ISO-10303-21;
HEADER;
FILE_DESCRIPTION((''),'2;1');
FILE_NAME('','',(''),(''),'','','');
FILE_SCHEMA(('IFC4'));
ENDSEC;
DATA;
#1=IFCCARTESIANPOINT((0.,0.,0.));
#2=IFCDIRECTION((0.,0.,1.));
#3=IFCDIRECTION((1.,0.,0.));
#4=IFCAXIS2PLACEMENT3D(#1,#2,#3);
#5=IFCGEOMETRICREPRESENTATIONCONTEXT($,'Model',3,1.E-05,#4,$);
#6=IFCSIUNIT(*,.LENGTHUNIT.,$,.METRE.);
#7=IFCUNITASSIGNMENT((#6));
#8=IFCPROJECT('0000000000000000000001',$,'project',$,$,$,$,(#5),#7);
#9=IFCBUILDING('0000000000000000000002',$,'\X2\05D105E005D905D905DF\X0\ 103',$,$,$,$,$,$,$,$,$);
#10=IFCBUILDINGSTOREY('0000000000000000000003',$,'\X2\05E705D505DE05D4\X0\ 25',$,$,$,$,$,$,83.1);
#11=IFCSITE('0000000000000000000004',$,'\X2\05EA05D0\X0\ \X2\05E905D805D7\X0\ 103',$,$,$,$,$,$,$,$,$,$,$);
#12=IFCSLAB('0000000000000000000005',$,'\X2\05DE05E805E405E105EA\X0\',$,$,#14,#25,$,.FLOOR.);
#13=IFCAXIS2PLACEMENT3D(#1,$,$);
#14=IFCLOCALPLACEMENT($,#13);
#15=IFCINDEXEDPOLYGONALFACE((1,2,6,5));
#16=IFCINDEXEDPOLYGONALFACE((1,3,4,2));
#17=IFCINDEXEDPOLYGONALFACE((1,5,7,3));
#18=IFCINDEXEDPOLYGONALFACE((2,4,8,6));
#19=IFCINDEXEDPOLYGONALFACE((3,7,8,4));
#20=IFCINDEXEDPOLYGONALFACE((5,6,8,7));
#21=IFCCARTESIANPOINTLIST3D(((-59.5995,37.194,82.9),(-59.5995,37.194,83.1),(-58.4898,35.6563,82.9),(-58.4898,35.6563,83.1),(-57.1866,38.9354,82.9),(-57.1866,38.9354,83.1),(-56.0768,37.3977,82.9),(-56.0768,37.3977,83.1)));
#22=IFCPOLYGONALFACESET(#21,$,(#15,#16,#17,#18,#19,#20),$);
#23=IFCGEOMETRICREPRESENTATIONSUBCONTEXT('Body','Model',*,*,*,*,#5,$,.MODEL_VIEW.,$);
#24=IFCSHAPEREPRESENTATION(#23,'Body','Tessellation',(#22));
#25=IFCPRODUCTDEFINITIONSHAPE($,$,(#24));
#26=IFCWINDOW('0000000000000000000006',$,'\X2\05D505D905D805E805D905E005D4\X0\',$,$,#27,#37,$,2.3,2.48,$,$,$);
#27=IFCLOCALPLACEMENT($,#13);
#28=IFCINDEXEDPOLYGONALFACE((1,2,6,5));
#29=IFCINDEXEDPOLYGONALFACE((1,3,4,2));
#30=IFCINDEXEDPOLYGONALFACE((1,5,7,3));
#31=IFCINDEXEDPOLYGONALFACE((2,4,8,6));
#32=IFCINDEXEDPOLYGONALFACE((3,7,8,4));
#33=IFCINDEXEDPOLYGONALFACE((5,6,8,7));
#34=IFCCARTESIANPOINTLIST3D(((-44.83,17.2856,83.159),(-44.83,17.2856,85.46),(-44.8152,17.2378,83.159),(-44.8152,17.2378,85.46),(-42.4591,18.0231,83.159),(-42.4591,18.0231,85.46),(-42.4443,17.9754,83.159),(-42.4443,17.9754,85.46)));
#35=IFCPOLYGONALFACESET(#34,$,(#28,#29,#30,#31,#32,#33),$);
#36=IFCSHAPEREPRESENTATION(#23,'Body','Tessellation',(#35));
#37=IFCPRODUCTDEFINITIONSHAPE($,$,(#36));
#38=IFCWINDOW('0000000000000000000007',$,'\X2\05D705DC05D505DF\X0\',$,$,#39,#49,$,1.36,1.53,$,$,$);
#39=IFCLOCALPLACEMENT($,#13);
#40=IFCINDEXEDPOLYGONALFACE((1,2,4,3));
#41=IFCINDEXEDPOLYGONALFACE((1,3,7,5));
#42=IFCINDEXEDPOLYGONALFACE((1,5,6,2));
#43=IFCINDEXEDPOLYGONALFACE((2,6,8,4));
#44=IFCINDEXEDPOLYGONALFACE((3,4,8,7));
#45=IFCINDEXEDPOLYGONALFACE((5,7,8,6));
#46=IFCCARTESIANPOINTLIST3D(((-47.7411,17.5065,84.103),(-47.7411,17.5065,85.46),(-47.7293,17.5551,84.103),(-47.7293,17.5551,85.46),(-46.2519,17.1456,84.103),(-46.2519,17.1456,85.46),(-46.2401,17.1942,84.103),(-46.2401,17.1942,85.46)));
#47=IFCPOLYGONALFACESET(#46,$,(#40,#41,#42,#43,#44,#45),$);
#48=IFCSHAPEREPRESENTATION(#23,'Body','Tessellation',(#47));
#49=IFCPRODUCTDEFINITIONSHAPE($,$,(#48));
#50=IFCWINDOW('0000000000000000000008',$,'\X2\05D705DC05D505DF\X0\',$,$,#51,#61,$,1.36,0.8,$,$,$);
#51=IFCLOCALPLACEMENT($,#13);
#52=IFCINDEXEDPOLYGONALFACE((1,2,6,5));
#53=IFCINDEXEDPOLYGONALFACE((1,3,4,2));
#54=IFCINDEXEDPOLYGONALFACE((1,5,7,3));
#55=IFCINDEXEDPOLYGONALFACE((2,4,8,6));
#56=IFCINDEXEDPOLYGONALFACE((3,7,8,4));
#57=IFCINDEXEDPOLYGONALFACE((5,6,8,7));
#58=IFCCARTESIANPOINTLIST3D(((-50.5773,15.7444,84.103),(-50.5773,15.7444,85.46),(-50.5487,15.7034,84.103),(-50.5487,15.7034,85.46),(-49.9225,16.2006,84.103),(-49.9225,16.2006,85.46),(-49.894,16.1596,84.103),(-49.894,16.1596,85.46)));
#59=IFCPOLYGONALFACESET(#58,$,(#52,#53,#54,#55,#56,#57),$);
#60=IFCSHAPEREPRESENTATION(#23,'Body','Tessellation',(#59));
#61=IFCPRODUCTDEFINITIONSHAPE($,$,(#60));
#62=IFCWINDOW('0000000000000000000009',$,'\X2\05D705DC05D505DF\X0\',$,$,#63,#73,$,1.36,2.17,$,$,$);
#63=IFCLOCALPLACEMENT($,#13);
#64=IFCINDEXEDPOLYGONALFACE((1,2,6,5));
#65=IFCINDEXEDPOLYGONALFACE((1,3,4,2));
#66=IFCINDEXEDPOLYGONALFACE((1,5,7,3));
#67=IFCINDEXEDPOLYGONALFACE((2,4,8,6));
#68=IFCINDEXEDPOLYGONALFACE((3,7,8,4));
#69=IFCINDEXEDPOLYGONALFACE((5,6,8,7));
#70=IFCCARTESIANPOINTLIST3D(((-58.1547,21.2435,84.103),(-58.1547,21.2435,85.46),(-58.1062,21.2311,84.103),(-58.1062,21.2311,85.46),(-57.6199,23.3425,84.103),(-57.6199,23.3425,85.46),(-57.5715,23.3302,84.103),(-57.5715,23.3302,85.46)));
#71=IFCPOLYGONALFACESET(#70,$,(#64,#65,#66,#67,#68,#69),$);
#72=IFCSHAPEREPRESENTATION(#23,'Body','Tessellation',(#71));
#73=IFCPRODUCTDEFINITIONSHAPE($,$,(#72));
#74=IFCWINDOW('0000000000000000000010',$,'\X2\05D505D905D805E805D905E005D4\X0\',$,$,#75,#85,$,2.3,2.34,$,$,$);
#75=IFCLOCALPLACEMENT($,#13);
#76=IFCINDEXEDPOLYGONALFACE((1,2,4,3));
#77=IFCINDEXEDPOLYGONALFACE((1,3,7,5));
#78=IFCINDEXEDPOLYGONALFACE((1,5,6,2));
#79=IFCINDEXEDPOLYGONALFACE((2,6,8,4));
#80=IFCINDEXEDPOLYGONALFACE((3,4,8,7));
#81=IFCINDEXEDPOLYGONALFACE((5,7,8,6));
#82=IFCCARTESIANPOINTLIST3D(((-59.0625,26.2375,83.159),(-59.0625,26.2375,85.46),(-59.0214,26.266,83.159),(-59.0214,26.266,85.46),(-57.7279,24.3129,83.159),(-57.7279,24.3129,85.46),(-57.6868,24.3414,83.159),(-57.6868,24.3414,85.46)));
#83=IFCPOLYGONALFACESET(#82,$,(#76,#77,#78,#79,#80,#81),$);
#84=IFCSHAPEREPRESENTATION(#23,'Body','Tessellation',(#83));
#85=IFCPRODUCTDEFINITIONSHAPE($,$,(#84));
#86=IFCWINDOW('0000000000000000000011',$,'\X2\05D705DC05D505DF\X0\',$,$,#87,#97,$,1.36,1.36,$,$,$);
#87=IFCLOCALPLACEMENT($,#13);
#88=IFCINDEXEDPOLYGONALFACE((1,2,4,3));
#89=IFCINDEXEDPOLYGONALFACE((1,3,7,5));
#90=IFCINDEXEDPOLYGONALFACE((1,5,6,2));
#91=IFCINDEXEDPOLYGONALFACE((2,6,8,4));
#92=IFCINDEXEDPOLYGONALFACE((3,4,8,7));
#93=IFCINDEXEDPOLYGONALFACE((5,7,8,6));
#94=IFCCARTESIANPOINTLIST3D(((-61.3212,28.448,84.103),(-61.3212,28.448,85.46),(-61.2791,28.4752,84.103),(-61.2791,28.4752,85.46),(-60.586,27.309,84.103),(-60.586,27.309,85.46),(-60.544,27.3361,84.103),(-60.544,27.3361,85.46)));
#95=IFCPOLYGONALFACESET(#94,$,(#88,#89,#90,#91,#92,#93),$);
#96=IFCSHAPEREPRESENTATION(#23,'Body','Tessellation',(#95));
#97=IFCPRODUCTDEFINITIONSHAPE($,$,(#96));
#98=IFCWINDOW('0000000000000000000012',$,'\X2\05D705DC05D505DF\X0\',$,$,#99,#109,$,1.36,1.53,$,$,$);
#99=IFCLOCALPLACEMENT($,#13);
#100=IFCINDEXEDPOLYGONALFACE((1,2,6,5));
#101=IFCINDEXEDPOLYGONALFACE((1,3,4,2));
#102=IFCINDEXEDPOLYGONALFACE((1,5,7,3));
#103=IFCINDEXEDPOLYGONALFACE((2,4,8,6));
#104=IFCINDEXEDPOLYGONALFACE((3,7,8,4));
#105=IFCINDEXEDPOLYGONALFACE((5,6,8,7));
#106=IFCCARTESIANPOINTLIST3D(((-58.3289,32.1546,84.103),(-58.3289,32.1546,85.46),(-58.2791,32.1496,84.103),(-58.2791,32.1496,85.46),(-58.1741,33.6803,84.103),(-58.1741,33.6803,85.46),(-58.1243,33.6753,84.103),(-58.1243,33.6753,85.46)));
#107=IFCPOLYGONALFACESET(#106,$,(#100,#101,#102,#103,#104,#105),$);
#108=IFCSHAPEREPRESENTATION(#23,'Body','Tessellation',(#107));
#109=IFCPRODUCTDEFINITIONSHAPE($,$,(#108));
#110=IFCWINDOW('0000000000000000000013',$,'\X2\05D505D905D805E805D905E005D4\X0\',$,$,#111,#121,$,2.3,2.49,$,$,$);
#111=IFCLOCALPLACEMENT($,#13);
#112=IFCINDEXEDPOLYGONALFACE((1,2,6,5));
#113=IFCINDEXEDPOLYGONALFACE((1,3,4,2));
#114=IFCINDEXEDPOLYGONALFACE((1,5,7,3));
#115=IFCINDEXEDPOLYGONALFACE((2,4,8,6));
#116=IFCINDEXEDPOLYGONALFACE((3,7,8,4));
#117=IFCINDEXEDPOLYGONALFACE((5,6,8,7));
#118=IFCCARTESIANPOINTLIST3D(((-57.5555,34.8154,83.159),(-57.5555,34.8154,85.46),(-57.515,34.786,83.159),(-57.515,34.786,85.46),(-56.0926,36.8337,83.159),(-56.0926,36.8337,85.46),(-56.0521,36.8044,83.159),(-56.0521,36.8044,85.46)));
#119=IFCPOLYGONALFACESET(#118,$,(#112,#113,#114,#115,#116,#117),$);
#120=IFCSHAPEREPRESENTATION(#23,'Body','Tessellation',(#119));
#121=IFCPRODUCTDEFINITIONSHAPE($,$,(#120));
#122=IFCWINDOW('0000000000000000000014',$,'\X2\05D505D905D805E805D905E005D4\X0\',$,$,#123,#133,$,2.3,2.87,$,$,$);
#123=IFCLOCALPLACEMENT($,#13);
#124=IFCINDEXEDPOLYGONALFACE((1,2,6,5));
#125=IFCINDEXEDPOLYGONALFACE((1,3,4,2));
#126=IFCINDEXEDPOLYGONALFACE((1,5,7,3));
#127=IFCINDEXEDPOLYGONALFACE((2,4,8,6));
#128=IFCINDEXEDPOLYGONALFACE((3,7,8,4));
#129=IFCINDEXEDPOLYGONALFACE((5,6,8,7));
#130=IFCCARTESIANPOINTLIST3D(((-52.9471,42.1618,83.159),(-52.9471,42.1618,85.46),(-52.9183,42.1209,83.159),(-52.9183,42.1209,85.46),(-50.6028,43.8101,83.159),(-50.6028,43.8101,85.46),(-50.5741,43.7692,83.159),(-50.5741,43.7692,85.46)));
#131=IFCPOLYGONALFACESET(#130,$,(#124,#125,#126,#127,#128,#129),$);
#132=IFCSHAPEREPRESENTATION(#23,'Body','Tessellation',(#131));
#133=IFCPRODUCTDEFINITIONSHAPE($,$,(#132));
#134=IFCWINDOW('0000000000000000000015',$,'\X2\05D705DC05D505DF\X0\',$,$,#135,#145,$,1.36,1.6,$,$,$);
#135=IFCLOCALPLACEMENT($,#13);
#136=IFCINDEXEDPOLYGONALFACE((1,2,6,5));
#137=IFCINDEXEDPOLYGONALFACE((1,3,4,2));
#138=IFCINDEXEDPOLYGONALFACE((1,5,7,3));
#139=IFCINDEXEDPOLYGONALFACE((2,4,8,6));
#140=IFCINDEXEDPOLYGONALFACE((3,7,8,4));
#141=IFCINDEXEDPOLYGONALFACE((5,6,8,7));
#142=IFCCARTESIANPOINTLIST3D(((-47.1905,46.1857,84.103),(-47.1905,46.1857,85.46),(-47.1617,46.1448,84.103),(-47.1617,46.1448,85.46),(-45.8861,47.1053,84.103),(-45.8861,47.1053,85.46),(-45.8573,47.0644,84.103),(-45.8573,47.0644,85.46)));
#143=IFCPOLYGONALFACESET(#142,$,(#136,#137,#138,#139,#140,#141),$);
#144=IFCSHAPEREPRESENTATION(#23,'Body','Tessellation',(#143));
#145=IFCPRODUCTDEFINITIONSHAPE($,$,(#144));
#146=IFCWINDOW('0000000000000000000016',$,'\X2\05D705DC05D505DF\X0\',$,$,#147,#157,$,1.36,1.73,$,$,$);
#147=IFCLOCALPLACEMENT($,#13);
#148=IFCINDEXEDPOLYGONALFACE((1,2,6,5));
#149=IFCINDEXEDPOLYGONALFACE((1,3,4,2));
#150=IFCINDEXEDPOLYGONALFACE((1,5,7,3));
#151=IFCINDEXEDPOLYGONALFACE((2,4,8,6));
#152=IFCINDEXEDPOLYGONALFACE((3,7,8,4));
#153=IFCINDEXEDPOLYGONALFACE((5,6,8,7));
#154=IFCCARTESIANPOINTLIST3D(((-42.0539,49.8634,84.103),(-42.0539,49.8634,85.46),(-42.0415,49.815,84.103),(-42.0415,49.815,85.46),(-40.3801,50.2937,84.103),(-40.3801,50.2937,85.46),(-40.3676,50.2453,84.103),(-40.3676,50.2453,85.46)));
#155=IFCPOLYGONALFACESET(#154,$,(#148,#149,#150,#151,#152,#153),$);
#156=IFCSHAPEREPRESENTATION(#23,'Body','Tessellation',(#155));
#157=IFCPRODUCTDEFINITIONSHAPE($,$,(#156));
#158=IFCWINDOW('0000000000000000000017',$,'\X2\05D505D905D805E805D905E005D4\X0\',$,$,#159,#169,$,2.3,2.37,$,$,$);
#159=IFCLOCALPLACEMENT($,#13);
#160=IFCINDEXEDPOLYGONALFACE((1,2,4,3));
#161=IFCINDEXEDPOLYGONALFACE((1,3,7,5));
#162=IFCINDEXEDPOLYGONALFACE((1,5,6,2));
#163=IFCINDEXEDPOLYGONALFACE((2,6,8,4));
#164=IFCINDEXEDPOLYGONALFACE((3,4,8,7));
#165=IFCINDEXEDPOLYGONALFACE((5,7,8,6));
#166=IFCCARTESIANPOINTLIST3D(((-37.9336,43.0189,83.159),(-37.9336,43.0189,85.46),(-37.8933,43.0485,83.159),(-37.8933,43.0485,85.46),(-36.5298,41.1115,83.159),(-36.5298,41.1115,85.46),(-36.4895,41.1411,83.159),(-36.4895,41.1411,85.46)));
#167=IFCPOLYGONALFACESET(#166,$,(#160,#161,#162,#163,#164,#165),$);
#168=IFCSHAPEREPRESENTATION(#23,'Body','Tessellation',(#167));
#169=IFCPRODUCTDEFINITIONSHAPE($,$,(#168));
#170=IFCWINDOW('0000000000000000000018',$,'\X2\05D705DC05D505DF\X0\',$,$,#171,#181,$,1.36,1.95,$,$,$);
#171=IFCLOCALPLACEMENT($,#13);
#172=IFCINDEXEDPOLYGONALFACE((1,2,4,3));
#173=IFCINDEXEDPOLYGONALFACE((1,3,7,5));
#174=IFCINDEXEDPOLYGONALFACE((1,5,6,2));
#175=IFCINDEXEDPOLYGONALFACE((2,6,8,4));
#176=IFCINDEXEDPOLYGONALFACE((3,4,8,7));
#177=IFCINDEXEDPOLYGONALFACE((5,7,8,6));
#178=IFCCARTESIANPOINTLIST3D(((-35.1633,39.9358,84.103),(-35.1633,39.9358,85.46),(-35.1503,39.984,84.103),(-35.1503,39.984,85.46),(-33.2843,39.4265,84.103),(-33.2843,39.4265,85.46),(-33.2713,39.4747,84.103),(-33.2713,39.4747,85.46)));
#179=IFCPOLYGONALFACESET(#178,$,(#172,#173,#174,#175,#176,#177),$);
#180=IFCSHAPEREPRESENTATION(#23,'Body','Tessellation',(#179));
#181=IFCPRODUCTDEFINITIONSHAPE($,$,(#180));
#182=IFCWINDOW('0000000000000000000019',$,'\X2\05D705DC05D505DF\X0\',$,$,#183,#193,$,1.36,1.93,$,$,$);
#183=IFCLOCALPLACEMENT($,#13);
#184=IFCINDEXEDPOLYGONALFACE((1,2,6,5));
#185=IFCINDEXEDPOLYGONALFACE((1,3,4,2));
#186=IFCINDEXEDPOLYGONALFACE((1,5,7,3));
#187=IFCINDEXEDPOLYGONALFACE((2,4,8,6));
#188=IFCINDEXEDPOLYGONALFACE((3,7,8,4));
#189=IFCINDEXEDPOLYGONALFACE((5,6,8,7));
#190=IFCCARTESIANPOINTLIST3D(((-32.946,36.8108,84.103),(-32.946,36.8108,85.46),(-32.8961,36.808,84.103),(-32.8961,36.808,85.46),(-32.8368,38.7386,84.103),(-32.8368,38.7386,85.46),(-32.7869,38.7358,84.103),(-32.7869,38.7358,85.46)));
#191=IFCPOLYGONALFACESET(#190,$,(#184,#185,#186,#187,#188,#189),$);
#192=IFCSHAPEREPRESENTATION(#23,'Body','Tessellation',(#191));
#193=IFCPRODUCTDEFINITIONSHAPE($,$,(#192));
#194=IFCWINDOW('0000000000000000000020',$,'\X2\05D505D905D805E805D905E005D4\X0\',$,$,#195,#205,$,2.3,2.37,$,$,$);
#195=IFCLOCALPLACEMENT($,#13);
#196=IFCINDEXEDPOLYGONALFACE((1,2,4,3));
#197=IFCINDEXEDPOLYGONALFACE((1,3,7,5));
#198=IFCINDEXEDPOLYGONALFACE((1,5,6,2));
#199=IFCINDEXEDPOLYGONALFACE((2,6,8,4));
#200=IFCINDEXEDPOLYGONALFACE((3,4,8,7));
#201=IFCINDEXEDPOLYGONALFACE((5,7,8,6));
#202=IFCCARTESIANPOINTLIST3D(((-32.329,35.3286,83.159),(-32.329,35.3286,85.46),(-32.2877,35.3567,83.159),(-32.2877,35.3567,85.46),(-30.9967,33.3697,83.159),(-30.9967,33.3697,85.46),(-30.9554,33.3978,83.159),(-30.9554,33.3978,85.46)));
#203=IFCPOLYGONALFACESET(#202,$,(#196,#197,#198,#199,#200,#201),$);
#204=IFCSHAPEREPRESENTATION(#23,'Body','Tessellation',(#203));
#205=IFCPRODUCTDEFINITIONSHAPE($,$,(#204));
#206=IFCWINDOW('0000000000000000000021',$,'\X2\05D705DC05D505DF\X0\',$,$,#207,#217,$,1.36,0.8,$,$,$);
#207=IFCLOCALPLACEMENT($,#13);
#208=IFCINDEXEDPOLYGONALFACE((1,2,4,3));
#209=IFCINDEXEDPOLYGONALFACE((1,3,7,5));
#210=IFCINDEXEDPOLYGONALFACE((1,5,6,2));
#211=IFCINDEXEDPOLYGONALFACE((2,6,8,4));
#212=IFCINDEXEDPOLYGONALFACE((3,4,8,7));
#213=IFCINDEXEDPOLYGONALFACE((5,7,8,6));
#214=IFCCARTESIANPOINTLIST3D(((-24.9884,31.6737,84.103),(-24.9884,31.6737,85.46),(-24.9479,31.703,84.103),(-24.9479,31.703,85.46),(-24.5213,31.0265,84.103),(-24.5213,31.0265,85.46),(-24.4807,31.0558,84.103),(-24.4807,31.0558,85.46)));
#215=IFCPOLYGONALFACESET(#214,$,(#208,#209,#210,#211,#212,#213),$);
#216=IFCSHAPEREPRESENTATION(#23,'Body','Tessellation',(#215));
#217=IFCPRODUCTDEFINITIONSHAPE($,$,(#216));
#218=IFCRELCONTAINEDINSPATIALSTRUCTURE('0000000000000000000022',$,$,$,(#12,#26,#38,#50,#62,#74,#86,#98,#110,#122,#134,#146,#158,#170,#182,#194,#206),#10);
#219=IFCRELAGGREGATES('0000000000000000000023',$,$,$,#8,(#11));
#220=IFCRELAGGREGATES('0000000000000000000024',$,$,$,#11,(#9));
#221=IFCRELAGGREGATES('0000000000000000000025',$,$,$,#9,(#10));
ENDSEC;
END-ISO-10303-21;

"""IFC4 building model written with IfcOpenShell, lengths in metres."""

from ifc_helpers import new_model, si_unit, frame, origin_with_axes, context, subcontext, project, spatial, polyline, outline, extrude, element, save


model = new_model("IFC4")

# Units and contexts
model_context = context("Model", 3, precision=1e-05, world=origin_with_axes())
body_context = subcontext(model_context, "Body", "Model", "MODEL_VIEW")
ifc_project = project(units=[si_unit("LENGTHUNIT", "METRE")], contexts=[model_context])

# Site, building, storey
site = spatial("IfcSite", under=ifc_project, Name="תא שטח 103")
building = spatial("IfcBuilding", under=site, Name="בניין 103")
storey = spatial("IfcBuildingStorey", under=building, Name="קומה 25", Elevation=83.1)

# Slab
element("IfcSlab", 1, inside=storey, Name="מרפסת", PredefinedType="FLOOR", context=body_context, shape_type="SweptSolid", body=[
    extrude(outline(polyline([(-56.0768, 37.3977), (-57.1866, 38.9354), (-59.5995, 37.194), (-58.4898, 35.6563), (-56.0768, 37.3977)])), frame((0.0, 0.0, 82.9)), (0.0, 0.0, 1.0), 0.2),
])

# Windows
element("IfcWindow", 2, inside=storey, Name="ויטרינה", OverallHeight=2.3, OverallWidth=2.48, context=body_context, shape_type="SweptSolid", body=[
    extrude(outline(polyline([(-42.4591, 18.0231), (-44.83, 17.2856), (-44.8152, 17.2378), (-42.4443, 17.9754), (-42.4591, 18.0231)])), frame((0.0, 0.0, 83.159)), (0.0, 0.0, 1.0), 2.301),
])
element("IfcWindow", 3, inside=storey, Name="חלון", OverallHeight=1.36, OverallWidth=1.53, context=body_context, shape_type="SweptSolid", body=[
    extrude(outline(polyline([(-46.2401, 17.1942), (-47.7293, 17.5551), (-47.7411, 17.5065), (-46.2519, 17.1456), (-46.2401, 17.1942)])), frame((0.0, 0.0, 84.103)), (0.0, 0.0, 1.0), 1.357),
])
element("IfcWindow", 4, inside=storey, Name="חלון", OverallHeight=1.36, OverallWidth=0.8, context=body_context, shape_type="SweptSolid", body=[
    extrude(outline(polyline([(-49.9225, 16.2006), (-50.5773, 15.7444), (-50.5487, 15.7034), (-49.894, 16.1596), (-49.9225, 16.2006)])), frame((0.0, 0.0, 84.103)), (0.0, 0.0, 1.0), 1.357),
])
element("IfcWindow", 5, inside=storey, Name="חלון", OverallHeight=1.36, OverallWidth=2.17, context=body_context, shape_type="SweptSolid", body=[
    extrude(outline(polyline([(-58.1062, 21.2311), (-57.5715, 23.3302), (-57.6199, 23.3425), (-58.1547, 21.2435), (-58.1062, 21.2311)])), frame((0.0, 0.0, 84.103)), (0.0, 0.0, 1.0), 1.357),
])
element("IfcWindow", 6, inside=storey, Name="ויטרינה", OverallHeight=2.3, OverallWidth=2.34, context=body_context, shape_type="SweptSolid", body=[
    extrude(outline(polyline([(-57.6868, 24.3414), (-59.0214, 26.266), (-59.0625, 26.2375), (-57.7279, 24.3129), (-57.6868, 24.3414)])), frame((0.0, 0.0, 83.159)), (0.0, 0.0, 1.0), 2.301),
])
element("IfcWindow", 7, inside=storey, Name="חלון", OverallHeight=1.36, OverallWidth=1.36, context=body_context, shape_type="SweptSolid", body=[
    extrude(outline(polyline([(-60.544, 27.3361), (-61.2791, 28.4752), (-61.3212, 28.448), (-60.586, 27.309), (-60.544, 27.3361)])), frame((0.0, 0.0, 84.103)), (0.0, 0.0, 1.0), 1.357),
])
element("IfcWindow", 8, inside=storey, Name="חלון", OverallHeight=1.36, OverallWidth=1.53, context=body_context, shape_type="SweptSolid", body=[
    extrude(outline(polyline([(-58.2791, 32.1496), (-58.1243, 33.6753), (-58.1741, 33.6803), (-58.3289, 32.1546), (-58.2791, 32.1496)])), frame((0.0, 0.0, 84.103)), (0.0, 0.0, 1.0), 1.357),
])
element("IfcWindow", 9, inside=storey, Name="ויטרינה", OverallHeight=2.3, OverallWidth=2.49, context=body_context, shape_type="SweptSolid", body=[
    extrude(outline(polyline([(-57.515, 34.786), (-56.0521, 36.8044), (-56.0926, 36.8337), (-57.5555, 34.8154), (-57.515, 34.786)])), frame((0.0, 0.0, 83.159)), (0.0, 0.0, 1.0), 2.301),
])
element("IfcWindow", 10, inside=storey, Name="ויטרינה", OverallHeight=2.3, OverallWidth=2.87, context=body_context, shape_type="SweptSolid", body=[
    extrude(outline(polyline([(-52.9183, 42.1209), (-50.5741, 43.7692), (-50.6028, 43.8101), (-52.9471, 42.1618), (-52.9183, 42.1209)])), frame((0.0, 0.0, 83.159)), (0.0, 0.0, 1.0), 2.301),
])
element("IfcWindow", 11, inside=storey, Name="חלון", OverallHeight=1.36, OverallWidth=1.6, context=body_context, shape_type="SweptSolid", body=[
    extrude(outline(polyline([(-47.1617, 46.1448), (-45.8573, 47.0644), (-45.8861, 47.1053), (-47.1905, 46.1857), (-47.1617, 46.1448)])), frame((0.0, 0.0, 84.103)), (0.0, 0.0, 1.0), 1.357),
])
element("IfcWindow", 12, inside=storey, Name="חלון", OverallHeight=1.36, OverallWidth=1.73, context=body_context, shape_type="SweptSolid", body=[
    extrude(outline(polyline([(-42.0415, 49.815), (-40.3676, 50.2453), (-40.3801, 50.2937), (-42.0539, 49.8634), (-42.0415, 49.815)])), frame((0.0, 0.0, 84.103)), (0.0, 0.0, 1.0), 1.357),
])
element("IfcWindow", 13, inside=storey, Name="ויטרינה", OverallHeight=2.3, OverallWidth=2.37, context=body_context, shape_type="SweptSolid", body=[
    extrude(outline(polyline([(-37.9336, 43.0189), (-36.5298, 41.1115), (-36.4895, 41.1411), (-37.8933, 43.0485), (-37.9336, 43.0189)])), frame((0.0, 0.0, 83.159)), (0.0, 0.0, 1.0), 2.301),
])
element("IfcWindow", 14, inside=storey, Name="חלון", OverallHeight=1.36, OverallWidth=1.95, context=body_context, shape_type="SweptSolid", body=[
    extrude(outline(polyline([(-35.1633, 39.9358), (-33.2843, 39.4265), (-33.2713, 39.4747), (-35.1503, 39.984), (-35.1633, 39.9358)])), frame((0.0, 0.0, 84.103)), (0.0, 0.0, 1.0), 1.357),
])
element("IfcWindow", 15, inside=storey, Name="חלון", OverallHeight=1.36, OverallWidth=1.93, context=body_context, shape_type="SweptSolid", body=[
    extrude(outline(polyline([(-32.8368, 38.7386), (-32.946, 36.8108), (-32.8961, 36.808), (-32.7869, 38.7358), (-32.8368, 38.7386)])), frame((0.0, 0.0, 84.103)), (0.0, 0.0, 1.0), 1.357),
])
element("IfcWindow", 16, inside=storey, Name="ויטרינה", OverallHeight=2.3, OverallWidth=2.37, context=body_context, shape_type="SweptSolid", body=[
    extrude(outline(polyline([(-32.329, 35.3286), (-30.9967, 33.3697), (-30.9554, 33.3978), (-32.2877, 35.3567), (-32.329, 35.3286)])), frame((0.0, 0.0, 83.159)), (0.0, 0.0, 1.0), 2.301),
])
element("IfcWindow", 17, inside=storey, Name="חלון", OverallHeight=1.36, OverallWidth=0.8, context=body_context, shape_type="SweptSolid", body=[
    extrude(outline(polyline([(-24.9884, 31.6737), (-24.5213, 31.0265), (-24.4807, 31.0558), (-24.9479, 31.703), (-24.9884, 31.6737)])), frame((0.0, 0.0, 84.103)), (0.0, 0.0, 1.0), 1.357),
])

save(model, "model.ifc")
